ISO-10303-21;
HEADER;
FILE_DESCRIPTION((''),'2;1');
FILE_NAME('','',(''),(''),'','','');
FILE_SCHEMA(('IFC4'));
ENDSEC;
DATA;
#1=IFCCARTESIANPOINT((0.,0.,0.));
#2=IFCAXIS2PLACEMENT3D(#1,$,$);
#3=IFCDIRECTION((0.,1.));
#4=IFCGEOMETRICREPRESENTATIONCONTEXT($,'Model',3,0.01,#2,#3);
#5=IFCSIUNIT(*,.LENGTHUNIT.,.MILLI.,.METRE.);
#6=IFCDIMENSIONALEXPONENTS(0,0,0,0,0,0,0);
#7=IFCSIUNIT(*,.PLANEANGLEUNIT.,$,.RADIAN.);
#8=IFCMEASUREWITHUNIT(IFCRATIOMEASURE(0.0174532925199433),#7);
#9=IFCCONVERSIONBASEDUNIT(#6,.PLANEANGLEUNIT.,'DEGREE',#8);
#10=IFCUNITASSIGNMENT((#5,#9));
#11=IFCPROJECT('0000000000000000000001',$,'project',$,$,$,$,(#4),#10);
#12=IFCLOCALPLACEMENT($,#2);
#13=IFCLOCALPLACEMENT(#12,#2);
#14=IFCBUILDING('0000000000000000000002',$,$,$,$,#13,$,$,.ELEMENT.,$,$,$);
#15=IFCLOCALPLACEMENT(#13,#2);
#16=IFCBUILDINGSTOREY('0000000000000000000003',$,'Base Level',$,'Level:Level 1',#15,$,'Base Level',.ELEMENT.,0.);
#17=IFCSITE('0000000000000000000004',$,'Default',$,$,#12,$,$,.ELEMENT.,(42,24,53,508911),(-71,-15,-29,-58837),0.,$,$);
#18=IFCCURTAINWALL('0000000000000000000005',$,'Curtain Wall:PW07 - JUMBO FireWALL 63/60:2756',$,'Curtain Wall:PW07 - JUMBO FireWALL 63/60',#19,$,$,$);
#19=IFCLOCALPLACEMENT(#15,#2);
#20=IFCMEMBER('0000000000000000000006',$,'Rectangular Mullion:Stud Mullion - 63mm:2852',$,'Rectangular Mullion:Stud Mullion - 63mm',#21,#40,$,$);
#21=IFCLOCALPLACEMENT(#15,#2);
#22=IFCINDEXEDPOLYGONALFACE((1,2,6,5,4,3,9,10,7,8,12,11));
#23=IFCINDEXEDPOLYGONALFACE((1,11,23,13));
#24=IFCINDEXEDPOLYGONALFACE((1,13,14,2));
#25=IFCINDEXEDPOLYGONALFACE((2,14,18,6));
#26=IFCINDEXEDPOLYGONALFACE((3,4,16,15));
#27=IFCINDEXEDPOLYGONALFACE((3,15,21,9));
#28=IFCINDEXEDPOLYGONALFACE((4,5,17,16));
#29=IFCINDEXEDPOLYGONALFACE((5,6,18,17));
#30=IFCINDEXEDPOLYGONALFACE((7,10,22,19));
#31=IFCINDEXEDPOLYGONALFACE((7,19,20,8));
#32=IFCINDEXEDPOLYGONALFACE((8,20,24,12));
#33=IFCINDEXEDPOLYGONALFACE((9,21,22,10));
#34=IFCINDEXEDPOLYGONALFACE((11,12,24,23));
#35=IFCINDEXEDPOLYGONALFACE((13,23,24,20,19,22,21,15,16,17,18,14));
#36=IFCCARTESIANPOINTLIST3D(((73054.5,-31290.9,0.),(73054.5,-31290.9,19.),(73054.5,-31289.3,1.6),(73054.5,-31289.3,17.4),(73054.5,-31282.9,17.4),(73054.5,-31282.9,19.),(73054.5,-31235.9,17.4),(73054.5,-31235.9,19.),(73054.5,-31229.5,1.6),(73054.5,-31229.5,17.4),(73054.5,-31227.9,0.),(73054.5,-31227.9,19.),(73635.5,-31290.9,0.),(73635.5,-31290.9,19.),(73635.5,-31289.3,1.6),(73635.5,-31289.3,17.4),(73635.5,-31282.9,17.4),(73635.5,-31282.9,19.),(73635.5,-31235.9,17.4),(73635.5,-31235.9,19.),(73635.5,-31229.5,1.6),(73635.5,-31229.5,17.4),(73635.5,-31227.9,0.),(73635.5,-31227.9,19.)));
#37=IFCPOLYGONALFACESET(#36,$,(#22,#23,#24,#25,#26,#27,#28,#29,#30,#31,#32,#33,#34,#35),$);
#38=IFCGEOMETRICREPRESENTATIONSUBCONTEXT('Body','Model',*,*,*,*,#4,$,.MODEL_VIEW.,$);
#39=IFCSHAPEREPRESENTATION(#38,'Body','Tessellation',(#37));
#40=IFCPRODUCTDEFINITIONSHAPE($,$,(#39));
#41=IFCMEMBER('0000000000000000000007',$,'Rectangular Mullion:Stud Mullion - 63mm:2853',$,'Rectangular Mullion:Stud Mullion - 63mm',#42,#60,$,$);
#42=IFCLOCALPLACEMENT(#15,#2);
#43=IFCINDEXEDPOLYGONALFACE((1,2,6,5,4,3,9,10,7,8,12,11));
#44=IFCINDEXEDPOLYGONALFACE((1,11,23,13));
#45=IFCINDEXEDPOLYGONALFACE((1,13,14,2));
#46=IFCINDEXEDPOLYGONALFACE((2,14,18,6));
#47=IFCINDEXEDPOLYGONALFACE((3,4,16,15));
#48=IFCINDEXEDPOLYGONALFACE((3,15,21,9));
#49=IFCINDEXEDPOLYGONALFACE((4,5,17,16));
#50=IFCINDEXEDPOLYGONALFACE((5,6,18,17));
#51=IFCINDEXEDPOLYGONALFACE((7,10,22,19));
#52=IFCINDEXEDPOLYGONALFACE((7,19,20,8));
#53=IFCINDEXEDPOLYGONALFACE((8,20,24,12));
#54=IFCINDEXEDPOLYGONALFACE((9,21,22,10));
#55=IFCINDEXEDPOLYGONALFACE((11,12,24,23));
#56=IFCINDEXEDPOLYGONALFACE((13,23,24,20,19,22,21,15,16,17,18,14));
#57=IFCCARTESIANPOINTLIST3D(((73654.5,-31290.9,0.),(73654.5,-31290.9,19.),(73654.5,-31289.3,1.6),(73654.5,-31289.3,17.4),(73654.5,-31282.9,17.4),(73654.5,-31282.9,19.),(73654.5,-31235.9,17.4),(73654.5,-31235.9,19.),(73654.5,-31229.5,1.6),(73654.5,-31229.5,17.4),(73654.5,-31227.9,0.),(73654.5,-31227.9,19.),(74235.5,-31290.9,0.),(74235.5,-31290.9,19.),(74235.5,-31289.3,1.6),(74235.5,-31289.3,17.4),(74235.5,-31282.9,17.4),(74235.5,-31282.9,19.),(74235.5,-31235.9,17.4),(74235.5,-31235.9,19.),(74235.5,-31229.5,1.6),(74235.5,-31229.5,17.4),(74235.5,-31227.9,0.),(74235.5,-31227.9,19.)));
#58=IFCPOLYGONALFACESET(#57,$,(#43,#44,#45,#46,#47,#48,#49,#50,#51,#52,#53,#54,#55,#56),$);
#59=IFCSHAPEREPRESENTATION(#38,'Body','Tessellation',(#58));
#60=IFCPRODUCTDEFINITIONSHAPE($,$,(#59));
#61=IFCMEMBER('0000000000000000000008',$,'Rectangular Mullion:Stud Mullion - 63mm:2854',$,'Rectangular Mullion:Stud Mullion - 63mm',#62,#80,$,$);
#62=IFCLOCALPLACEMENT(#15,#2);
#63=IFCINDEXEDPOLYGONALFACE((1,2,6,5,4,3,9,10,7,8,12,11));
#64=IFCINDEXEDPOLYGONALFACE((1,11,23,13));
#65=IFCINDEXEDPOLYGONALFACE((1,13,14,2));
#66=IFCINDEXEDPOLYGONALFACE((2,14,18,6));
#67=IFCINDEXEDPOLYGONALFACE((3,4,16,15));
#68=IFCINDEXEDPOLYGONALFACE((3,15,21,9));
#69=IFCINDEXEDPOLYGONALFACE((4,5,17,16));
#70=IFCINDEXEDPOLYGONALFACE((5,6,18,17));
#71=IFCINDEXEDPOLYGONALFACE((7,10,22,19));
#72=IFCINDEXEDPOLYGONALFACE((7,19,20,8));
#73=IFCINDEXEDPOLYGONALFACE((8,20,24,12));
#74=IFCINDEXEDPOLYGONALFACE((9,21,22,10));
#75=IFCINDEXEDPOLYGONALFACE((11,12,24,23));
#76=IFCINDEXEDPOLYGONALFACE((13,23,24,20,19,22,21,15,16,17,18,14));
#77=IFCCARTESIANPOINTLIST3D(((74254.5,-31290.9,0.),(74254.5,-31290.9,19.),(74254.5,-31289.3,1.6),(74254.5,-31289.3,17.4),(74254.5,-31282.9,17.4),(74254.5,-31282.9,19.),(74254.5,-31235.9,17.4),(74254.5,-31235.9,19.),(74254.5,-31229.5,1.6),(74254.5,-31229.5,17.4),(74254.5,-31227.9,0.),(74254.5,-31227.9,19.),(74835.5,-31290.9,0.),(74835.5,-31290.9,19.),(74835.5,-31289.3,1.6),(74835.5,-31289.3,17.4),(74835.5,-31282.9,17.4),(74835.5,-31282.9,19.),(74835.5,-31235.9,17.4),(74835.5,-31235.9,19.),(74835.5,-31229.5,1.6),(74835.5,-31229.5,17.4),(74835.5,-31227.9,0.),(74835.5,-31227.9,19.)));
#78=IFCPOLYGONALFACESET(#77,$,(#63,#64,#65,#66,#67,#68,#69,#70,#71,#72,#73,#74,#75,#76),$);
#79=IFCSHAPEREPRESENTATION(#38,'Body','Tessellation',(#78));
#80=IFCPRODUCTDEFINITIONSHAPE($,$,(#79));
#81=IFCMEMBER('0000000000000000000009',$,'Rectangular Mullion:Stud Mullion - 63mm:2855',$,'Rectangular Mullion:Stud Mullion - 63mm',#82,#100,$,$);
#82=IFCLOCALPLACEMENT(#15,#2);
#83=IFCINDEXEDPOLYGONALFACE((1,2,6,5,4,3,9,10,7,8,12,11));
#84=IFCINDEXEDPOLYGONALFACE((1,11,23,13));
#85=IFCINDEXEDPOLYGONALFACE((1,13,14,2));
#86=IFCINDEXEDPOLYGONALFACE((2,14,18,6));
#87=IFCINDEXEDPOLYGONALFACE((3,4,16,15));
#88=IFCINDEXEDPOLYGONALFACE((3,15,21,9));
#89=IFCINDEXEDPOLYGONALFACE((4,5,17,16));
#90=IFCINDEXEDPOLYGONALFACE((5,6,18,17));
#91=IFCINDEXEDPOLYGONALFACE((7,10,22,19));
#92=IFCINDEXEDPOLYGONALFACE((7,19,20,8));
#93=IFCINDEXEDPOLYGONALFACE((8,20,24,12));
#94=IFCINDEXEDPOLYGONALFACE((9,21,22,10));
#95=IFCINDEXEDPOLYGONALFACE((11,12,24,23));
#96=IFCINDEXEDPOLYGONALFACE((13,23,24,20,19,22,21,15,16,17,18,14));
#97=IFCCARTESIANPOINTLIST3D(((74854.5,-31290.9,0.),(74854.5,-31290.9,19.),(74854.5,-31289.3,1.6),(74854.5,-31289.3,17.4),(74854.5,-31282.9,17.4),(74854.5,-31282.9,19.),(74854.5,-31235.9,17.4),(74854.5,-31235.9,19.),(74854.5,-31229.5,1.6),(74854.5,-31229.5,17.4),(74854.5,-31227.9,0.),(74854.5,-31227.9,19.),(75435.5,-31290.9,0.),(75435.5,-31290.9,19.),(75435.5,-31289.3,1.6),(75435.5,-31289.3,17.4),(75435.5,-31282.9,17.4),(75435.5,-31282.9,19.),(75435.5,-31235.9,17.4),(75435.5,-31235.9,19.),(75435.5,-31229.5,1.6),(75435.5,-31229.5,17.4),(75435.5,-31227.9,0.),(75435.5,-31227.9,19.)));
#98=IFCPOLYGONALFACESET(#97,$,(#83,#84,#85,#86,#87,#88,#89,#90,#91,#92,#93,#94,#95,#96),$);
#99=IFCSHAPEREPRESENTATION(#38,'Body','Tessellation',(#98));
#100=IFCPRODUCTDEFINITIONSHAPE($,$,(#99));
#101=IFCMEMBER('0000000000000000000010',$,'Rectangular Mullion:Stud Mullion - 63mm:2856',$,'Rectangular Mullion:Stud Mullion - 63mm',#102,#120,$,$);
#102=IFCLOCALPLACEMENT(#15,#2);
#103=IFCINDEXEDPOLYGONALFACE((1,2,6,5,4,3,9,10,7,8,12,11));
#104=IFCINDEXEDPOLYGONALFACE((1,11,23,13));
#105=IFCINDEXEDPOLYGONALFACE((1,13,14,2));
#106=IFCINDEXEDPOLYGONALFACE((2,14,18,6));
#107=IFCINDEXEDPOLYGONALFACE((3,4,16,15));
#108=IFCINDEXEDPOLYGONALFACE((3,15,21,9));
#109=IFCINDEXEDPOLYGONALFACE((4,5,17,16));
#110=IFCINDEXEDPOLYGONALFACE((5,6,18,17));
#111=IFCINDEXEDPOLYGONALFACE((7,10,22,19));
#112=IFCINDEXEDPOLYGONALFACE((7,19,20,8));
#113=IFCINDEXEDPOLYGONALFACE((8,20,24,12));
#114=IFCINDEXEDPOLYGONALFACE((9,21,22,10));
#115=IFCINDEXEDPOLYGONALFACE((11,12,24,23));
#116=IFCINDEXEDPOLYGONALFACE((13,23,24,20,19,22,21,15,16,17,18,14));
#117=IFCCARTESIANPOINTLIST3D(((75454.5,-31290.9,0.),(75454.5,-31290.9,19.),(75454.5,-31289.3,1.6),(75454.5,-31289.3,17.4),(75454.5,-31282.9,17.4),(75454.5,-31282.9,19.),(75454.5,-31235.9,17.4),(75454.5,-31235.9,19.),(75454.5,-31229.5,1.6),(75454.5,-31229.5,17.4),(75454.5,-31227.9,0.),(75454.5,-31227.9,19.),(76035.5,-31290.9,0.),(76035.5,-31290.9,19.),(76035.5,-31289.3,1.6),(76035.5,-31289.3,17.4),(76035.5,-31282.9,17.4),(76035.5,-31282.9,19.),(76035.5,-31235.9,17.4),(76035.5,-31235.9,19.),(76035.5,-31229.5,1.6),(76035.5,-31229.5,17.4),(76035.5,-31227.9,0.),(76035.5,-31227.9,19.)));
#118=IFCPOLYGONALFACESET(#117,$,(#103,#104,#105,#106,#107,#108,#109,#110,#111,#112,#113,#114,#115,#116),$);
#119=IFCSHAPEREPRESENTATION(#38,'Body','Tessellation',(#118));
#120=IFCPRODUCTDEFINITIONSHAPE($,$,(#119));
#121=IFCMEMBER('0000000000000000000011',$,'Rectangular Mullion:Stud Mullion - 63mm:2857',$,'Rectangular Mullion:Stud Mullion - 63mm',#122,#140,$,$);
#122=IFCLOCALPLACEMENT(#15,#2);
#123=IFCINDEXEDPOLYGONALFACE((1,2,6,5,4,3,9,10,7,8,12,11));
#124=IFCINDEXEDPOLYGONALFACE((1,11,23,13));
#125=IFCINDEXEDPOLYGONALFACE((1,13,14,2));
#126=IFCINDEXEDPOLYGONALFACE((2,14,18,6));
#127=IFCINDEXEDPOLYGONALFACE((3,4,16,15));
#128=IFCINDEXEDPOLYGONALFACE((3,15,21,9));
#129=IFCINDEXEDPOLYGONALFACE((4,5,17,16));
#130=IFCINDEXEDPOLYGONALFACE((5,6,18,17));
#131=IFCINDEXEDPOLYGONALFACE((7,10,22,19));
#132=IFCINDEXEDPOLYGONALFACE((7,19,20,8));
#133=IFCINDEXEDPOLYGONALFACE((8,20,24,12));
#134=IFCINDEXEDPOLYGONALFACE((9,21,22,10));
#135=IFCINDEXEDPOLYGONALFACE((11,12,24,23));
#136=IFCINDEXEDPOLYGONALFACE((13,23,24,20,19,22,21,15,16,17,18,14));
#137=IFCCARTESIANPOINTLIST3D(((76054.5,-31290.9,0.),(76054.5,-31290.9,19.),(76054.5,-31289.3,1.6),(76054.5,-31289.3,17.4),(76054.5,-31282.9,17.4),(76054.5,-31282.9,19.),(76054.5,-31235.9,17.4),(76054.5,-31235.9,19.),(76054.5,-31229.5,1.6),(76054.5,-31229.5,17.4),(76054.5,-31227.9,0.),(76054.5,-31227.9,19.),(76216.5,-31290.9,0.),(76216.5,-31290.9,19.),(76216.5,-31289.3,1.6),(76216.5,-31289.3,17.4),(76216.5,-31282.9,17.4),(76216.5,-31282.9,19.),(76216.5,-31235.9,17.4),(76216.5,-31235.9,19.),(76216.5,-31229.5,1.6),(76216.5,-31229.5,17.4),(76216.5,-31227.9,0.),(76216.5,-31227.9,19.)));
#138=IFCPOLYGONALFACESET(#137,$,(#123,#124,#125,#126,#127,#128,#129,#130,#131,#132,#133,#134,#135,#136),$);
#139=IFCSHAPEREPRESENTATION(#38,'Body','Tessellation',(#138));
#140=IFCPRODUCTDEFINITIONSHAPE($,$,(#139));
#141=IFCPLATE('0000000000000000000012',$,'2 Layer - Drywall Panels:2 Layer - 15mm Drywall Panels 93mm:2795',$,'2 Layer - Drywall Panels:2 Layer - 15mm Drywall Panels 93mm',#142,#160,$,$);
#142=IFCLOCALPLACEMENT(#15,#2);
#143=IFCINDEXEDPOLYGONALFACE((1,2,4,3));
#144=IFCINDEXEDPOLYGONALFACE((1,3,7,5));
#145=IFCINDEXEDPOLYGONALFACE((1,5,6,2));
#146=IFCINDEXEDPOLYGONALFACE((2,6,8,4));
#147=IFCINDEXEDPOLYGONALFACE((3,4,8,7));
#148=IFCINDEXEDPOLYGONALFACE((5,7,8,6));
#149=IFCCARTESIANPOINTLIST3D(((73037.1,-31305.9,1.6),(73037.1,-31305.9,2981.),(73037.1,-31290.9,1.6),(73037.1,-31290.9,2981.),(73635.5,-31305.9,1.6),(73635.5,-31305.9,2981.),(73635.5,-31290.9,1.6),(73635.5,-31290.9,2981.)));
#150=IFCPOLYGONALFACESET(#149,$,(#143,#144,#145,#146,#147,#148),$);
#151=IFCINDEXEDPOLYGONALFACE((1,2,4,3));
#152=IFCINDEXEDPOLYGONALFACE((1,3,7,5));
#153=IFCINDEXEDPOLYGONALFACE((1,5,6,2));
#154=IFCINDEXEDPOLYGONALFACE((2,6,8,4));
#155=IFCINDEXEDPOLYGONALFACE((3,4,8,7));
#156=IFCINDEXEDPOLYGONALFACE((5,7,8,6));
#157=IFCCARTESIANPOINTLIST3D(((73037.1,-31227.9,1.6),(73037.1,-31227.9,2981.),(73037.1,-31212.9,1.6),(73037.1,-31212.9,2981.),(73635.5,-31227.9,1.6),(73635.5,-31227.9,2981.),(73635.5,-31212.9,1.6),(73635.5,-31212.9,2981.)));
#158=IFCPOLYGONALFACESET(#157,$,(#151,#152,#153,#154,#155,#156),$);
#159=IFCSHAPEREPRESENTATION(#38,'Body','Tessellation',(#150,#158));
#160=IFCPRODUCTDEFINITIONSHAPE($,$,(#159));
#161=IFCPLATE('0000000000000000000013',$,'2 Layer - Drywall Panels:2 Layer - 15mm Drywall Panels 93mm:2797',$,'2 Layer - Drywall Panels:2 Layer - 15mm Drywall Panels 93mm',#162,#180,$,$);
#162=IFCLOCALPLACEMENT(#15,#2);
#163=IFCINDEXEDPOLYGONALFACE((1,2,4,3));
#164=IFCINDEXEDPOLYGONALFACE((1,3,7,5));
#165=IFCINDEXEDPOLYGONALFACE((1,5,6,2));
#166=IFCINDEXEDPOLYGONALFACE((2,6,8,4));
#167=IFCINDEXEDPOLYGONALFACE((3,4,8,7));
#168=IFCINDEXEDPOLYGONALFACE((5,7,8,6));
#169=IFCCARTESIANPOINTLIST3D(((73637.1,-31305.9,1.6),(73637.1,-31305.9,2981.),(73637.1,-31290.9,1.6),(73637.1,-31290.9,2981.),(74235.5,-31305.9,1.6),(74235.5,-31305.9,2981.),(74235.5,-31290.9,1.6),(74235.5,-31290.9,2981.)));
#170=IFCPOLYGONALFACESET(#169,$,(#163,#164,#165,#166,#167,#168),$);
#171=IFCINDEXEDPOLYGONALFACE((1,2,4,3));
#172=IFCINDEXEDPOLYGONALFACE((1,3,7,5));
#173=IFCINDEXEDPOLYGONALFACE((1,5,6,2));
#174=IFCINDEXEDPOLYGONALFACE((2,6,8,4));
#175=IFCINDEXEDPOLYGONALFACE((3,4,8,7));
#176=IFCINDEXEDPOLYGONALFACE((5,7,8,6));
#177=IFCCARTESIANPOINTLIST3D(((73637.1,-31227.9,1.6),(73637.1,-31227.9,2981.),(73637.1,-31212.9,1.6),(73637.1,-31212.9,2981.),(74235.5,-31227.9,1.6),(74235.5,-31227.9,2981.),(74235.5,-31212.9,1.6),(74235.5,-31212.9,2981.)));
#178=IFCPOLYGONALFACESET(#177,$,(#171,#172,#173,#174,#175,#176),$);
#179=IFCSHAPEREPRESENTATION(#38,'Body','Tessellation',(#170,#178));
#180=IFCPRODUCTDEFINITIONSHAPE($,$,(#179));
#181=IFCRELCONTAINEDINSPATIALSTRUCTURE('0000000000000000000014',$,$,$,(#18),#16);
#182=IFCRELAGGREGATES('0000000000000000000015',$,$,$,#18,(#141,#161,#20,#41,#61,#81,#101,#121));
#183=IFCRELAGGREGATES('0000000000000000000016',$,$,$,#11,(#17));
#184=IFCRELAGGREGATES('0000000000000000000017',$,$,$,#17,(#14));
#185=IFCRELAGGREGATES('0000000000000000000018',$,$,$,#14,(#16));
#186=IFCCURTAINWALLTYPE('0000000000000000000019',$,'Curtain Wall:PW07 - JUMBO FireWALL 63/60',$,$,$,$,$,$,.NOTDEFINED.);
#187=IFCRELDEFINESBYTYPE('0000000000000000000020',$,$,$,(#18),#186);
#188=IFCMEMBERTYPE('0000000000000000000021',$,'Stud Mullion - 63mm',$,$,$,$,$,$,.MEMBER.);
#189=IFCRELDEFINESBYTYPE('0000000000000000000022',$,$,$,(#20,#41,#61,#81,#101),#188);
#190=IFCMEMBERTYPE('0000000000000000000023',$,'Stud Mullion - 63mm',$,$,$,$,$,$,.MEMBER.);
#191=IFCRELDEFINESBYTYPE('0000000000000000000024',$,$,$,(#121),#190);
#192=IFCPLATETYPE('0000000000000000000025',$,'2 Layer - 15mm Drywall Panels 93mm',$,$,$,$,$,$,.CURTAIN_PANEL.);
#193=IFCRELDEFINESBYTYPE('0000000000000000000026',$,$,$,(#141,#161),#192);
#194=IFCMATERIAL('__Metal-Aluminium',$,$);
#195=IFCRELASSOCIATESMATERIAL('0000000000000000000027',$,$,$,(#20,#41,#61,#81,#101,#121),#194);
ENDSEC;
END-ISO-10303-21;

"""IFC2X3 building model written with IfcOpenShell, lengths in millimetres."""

from ifc_helpers import new_model, entity, si_unit, converted_unit, direction, frame, frame_2d, origin, place, context, subcontext, project, spatial, polyline, rectangle, outline, extrude, source, transform, mapped, material, type_object, type_shapes, element, aggregate, save


model = new_model("IFC2X3")

# Units and contexts
model_context = context("Model", 3, precision=0.01, world=origin(), true_north=direction((0.0, 1.0)))
body_context = subcontext(model_context, "Body", "Model", "MODEL_VIEW")
ifc_project = project(units=[si_unit("LENGTHUNIT", "METRE", prefix="MILLI"), converted_unit("PLANEANGLEUNIT", "DEGREE", entity("IfcRatioMeasure", 0.0174532925199433), si_unit("PLANEANGLEUNIT", "RADIAN"), dimensions=[0, 0, 0, 0, 0, 0, 0])], contexts=[model_context])

# Site, building, storey
site_placement = place(None, origin())
site = spatial("IfcSite", under=ifc_project, at=site_placement, Name="Default", CompositionType="ELEMENT", RefLatitude=(42, 24, 53, 508911), RefLongitude=(-71, -15, -29, -58837), RefElevation=0.0)
building_placement = place(site_placement, origin())
building = spatial("IfcBuilding", under=site, at=building_placement, CompositionType="ELEMENT")
storey_placement = place(building_placement, origin())
storey = spatial("IfcBuildingStorey", under=building, at=storey_placement, Name="Base Level", ObjectType="Level:Level 1", LongName="Base Level", CompositionType="ELEMENT", Elevation=0.0)

# Curtain wall, members, plates
curtain_wall_type = type_object("IfcCurtainWallType", Name="Curtain Wall:PW07 - JUMBO FireWALL 63/60", PredefinedType="NOTDEFINED")
curtain_wall_placement = place(building_placement, origin())
curtain_wall = element("IfcCurtainWall", 1, at=curtain_wall_placement, inside=storey, type_object=curtain_wall_type, Name="Curtain Wall:PW07 - JUMBO FireWALL 63/60:2756", ObjectType="Curtain Wall:PW07 - JUMBO FireWALL 63/60")
ifc_material = material(Name="__Metal-Aluminium")
member_type_1 = type_object("IfcMemberType", Name="Stud Mullion - 63mm", PredefinedType="MEMBER")
shared_shape_1 = source(origin(), body_context, "Body", "SweptSolid", [
    extrude(outline(polyline([(23.5, -6.6), (31.5, -6.6), (31.5, 12.4), (-31.5, 12.4), (-31.5, -6.6), (-23.5, -6.6), (-23.5, -5.0), (-29.9, -5.0), (-29.9, 10.8), (29.9, 10.8), (29.9, -5.0), (23.5, -5.0), (23.5, -6.6)])), frame((-12.4, 0.0, -581.0), z_axis=(0.0, 0.0, 1.0), x_axis=(0.0, -1.0, 0.0)), (0.0, 0.0, 1.0), 581.0),
])
type_shapes(member_type_1, [shared_shape_1])
member_1_placement = place(building_placement, frame((73054.5, -31259.4, 0.0), z_axis=(-1.0, 0.0, 0.0), x_axis=(0.0, 0.0, -1.0)))
member_1 = element("IfcMember", 2, at=member_1_placement, type_object=member_type_1, material=ifc_material, Name="Rectangular Mullion:Stud Mullion - 63mm:2852", ObjectType="Rectangular Mullion:Stud Mullion - 63mm", context=body_context, shape_type="MappedRepresentation", body=[
    mapped(shared_shape_1, transform((0.0, 0.0, 0.0), scale=1.0)),
])
member_2_placement = place(building_placement, frame((73654.5, -31259.4, 0.0), z_axis=(-1.0, 0.0, 0.0), x_axis=(0.0, 0.0, -1.0)))
member_2 = element("IfcMember", 3, at=member_2_placement, type_object=member_type_1, material=ifc_material, Name="Rectangular Mullion:Stud Mullion - 63mm:2853", ObjectType="Rectangular Mullion:Stud Mullion - 63mm", context=body_context, shape_type="MappedRepresentation", body=[
    mapped(shared_shape_1, transform((0.0, 0.0, 0.0), scale=1.0)),
])
member_3_placement = place(building_placement, frame((74254.5, -31259.4, 0.0), z_axis=(-1.0, 0.0, 0.0), x_axis=(0.0, 0.0, -1.0)))
member_3 = element("IfcMember", 4, at=member_3_placement, type_object=member_type_1, material=ifc_material, Name="Rectangular Mullion:Stud Mullion - 63mm:2854", ObjectType="Rectangular Mullion:Stud Mullion - 63mm", context=body_context, shape_type="MappedRepresentation", body=[
    mapped(shared_shape_1, transform((0.0, 0.0, 0.0), scale=1.0)),
])
member_4_placement = place(building_placement, frame((74854.5, -31259.4, 0.0), z_axis=(-1.0, 0.0, 0.0), x_axis=(0.0, 0.0, -1.0)))
member_4 = element("IfcMember", 5, at=member_4_placement, type_object=member_type_1, material=ifc_material, Name="Rectangular Mullion:Stud Mullion - 63mm:2855", ObjectType="Rectangular Mullion:Stud Mullion - 63mm", context=body_context, shape_type="MappedRepresentation", body=[
    mapped(shared_shape_1, transform((0.0, 0.0, 0.0), scale=1.0)),
])
member_5_placement = place(building_placement, frame((75454.5, -31259.4, 0.0), z_axis=(-1.0, 0.0, 0.0), x_axis=(0.0, 0.0, -1.0)))
member_5 = element("IfcMember", 6, at=member_5_placement, type_object=member_type_1, material=ifc_material, Name="Rectangular Mullion:Stud Mullion - 63mm:2856", ObjectType="Rectangular Mullion:Stud Mullion - 63mm", context=body_context, shape_type="MappedRepresentation", body=[
    mapped(shared_shape_1, transform((0.0, 0.0, 0.0), scale=1.0)),
])
member_type_2 = type_object("IfcMemberType", Name="Stud Mullion - 63mm", PredefinedType="MEMBER")
shared_shape_2 = source(origin(), body_context, "Body", "SweptSolid", [
    extrude(outline(polyline([(23.5, -6.6), (31.5, -6.6), (31.5, 12.4), (-31.5, 12.4), (-31.5, -6.6), (-23.5, -6.6), (-23.5, -5.0), (-29.9, -5.0), (-29.9, 10.8), (29.9, 10.8), (29.9, -5.0), (23.5, -5.0), (23.5, -6.6)])), frame((-12.4, 0.0, -162.0), z_axis=(0.0, 0.0, 1.0), x_axis=(0.0, -1.0, 0.0)), (0.0, 0.0, 1.0), 162.0),
])
type_shapes(member_type_2, [shared_shape_2])
member_6_placement = place(building_placement, frame((76054.5, -31259.4, 0.0), z_axis=(-1.0, 0.0, 0.0), x_axis=(0.0, 0.0, -1.0)))
member_6 = element("IfcMember", 7, at=member_6_placement, type_object=member_type_2, material=ifc_material, Name="Rectangular Mullion:Stud Mullion - 63mm:2857", ObjectType="Rectangular Mullion:Stud Mullion - 63mm", context=body_context, shape_type="MappedRepresentation", body=[
    mapped(shared_shape_2, transform((0.0, 0.0, 0.0), scale=1.0)),
])
plate_type_1 = type_object("IfcPlateType", Name="2 Layer - 15mm Drywall Panels 93mm", PredefinedType="CURTAIN_PANEL")
shared_shape_3 = source(origin(), body_context, "Body", "SweptSolid", [
    extrude(rectangle(XDim=598.4, YDim=15.0, at=frame_2d((0.0, 0.0), x_axis=(1.0, 0.0))), frame((0.0, -39.0, 0.0), z_axis=(0.0, 0.0, 1.0), x_axis=(-1.0, 0.0, 0.0)), (0.0, 0.0, 1.0), 2979.4),
    extrude(rectangle(XDim=15.0, YDim=598.4, at=frame_2d((0.0, 0.0), x_axis=(1.0, 0.0))), frame((0.0, 39.0, 0.0), z_axis=(0.0, 0.0, 1.0), x_axis=(0.0, 1.0, 0.0)), (0.0, 0.0, 1.0), 2979.4),
])
type_shapes(plate_type_1, [shared_shape_3])
plate_1_placement = place(curtain_wall_placement, frame((73336.3, -31259.4, 1.6)))
plate_1 = element("IfcPlate", 8, at=plate_1_placement, type_object=plate_type_1, Name="2 Layer - Drywall Panels:2 Layer - 15mm Drywall Panels 93mm:2795", ObjectType="2 Layer - Drywall Panels:2 Layer - 15mm Drywall Panels 93mm", context=body_context, shape_type="MappedRepresentation", body=[
    mapped(shared_shape_3, transform((0.0, 0.0, 0.0), scale=1.0)),
])
plate_2_placement = place(curtain_wall_placement, frame((73936.3, -31259.4, 1.6)))
plate_2 = element("IfcPlate", 9, at=plate_2_placement, type_object=plate_type_1, Name="2 Layer - Drywall Panels:2 Layer - 15mm Drywall Panels 93mm:2797", ObjectType="2 Layer - Drywall Panels:2 Layer - 15mm Drywall Panels 93mm", context=body_context, shape_type="MappedRepresentation", body=[
    mapped(shared_shape_3, transform((0.0, 0.0, 0.0), scale=1.0)),
])
aggregate(curtain_wall, [plate_1, plate_2, member_1, member_2, member_3, member_4, member_5, member_6])

save(model, "model.ifc")
